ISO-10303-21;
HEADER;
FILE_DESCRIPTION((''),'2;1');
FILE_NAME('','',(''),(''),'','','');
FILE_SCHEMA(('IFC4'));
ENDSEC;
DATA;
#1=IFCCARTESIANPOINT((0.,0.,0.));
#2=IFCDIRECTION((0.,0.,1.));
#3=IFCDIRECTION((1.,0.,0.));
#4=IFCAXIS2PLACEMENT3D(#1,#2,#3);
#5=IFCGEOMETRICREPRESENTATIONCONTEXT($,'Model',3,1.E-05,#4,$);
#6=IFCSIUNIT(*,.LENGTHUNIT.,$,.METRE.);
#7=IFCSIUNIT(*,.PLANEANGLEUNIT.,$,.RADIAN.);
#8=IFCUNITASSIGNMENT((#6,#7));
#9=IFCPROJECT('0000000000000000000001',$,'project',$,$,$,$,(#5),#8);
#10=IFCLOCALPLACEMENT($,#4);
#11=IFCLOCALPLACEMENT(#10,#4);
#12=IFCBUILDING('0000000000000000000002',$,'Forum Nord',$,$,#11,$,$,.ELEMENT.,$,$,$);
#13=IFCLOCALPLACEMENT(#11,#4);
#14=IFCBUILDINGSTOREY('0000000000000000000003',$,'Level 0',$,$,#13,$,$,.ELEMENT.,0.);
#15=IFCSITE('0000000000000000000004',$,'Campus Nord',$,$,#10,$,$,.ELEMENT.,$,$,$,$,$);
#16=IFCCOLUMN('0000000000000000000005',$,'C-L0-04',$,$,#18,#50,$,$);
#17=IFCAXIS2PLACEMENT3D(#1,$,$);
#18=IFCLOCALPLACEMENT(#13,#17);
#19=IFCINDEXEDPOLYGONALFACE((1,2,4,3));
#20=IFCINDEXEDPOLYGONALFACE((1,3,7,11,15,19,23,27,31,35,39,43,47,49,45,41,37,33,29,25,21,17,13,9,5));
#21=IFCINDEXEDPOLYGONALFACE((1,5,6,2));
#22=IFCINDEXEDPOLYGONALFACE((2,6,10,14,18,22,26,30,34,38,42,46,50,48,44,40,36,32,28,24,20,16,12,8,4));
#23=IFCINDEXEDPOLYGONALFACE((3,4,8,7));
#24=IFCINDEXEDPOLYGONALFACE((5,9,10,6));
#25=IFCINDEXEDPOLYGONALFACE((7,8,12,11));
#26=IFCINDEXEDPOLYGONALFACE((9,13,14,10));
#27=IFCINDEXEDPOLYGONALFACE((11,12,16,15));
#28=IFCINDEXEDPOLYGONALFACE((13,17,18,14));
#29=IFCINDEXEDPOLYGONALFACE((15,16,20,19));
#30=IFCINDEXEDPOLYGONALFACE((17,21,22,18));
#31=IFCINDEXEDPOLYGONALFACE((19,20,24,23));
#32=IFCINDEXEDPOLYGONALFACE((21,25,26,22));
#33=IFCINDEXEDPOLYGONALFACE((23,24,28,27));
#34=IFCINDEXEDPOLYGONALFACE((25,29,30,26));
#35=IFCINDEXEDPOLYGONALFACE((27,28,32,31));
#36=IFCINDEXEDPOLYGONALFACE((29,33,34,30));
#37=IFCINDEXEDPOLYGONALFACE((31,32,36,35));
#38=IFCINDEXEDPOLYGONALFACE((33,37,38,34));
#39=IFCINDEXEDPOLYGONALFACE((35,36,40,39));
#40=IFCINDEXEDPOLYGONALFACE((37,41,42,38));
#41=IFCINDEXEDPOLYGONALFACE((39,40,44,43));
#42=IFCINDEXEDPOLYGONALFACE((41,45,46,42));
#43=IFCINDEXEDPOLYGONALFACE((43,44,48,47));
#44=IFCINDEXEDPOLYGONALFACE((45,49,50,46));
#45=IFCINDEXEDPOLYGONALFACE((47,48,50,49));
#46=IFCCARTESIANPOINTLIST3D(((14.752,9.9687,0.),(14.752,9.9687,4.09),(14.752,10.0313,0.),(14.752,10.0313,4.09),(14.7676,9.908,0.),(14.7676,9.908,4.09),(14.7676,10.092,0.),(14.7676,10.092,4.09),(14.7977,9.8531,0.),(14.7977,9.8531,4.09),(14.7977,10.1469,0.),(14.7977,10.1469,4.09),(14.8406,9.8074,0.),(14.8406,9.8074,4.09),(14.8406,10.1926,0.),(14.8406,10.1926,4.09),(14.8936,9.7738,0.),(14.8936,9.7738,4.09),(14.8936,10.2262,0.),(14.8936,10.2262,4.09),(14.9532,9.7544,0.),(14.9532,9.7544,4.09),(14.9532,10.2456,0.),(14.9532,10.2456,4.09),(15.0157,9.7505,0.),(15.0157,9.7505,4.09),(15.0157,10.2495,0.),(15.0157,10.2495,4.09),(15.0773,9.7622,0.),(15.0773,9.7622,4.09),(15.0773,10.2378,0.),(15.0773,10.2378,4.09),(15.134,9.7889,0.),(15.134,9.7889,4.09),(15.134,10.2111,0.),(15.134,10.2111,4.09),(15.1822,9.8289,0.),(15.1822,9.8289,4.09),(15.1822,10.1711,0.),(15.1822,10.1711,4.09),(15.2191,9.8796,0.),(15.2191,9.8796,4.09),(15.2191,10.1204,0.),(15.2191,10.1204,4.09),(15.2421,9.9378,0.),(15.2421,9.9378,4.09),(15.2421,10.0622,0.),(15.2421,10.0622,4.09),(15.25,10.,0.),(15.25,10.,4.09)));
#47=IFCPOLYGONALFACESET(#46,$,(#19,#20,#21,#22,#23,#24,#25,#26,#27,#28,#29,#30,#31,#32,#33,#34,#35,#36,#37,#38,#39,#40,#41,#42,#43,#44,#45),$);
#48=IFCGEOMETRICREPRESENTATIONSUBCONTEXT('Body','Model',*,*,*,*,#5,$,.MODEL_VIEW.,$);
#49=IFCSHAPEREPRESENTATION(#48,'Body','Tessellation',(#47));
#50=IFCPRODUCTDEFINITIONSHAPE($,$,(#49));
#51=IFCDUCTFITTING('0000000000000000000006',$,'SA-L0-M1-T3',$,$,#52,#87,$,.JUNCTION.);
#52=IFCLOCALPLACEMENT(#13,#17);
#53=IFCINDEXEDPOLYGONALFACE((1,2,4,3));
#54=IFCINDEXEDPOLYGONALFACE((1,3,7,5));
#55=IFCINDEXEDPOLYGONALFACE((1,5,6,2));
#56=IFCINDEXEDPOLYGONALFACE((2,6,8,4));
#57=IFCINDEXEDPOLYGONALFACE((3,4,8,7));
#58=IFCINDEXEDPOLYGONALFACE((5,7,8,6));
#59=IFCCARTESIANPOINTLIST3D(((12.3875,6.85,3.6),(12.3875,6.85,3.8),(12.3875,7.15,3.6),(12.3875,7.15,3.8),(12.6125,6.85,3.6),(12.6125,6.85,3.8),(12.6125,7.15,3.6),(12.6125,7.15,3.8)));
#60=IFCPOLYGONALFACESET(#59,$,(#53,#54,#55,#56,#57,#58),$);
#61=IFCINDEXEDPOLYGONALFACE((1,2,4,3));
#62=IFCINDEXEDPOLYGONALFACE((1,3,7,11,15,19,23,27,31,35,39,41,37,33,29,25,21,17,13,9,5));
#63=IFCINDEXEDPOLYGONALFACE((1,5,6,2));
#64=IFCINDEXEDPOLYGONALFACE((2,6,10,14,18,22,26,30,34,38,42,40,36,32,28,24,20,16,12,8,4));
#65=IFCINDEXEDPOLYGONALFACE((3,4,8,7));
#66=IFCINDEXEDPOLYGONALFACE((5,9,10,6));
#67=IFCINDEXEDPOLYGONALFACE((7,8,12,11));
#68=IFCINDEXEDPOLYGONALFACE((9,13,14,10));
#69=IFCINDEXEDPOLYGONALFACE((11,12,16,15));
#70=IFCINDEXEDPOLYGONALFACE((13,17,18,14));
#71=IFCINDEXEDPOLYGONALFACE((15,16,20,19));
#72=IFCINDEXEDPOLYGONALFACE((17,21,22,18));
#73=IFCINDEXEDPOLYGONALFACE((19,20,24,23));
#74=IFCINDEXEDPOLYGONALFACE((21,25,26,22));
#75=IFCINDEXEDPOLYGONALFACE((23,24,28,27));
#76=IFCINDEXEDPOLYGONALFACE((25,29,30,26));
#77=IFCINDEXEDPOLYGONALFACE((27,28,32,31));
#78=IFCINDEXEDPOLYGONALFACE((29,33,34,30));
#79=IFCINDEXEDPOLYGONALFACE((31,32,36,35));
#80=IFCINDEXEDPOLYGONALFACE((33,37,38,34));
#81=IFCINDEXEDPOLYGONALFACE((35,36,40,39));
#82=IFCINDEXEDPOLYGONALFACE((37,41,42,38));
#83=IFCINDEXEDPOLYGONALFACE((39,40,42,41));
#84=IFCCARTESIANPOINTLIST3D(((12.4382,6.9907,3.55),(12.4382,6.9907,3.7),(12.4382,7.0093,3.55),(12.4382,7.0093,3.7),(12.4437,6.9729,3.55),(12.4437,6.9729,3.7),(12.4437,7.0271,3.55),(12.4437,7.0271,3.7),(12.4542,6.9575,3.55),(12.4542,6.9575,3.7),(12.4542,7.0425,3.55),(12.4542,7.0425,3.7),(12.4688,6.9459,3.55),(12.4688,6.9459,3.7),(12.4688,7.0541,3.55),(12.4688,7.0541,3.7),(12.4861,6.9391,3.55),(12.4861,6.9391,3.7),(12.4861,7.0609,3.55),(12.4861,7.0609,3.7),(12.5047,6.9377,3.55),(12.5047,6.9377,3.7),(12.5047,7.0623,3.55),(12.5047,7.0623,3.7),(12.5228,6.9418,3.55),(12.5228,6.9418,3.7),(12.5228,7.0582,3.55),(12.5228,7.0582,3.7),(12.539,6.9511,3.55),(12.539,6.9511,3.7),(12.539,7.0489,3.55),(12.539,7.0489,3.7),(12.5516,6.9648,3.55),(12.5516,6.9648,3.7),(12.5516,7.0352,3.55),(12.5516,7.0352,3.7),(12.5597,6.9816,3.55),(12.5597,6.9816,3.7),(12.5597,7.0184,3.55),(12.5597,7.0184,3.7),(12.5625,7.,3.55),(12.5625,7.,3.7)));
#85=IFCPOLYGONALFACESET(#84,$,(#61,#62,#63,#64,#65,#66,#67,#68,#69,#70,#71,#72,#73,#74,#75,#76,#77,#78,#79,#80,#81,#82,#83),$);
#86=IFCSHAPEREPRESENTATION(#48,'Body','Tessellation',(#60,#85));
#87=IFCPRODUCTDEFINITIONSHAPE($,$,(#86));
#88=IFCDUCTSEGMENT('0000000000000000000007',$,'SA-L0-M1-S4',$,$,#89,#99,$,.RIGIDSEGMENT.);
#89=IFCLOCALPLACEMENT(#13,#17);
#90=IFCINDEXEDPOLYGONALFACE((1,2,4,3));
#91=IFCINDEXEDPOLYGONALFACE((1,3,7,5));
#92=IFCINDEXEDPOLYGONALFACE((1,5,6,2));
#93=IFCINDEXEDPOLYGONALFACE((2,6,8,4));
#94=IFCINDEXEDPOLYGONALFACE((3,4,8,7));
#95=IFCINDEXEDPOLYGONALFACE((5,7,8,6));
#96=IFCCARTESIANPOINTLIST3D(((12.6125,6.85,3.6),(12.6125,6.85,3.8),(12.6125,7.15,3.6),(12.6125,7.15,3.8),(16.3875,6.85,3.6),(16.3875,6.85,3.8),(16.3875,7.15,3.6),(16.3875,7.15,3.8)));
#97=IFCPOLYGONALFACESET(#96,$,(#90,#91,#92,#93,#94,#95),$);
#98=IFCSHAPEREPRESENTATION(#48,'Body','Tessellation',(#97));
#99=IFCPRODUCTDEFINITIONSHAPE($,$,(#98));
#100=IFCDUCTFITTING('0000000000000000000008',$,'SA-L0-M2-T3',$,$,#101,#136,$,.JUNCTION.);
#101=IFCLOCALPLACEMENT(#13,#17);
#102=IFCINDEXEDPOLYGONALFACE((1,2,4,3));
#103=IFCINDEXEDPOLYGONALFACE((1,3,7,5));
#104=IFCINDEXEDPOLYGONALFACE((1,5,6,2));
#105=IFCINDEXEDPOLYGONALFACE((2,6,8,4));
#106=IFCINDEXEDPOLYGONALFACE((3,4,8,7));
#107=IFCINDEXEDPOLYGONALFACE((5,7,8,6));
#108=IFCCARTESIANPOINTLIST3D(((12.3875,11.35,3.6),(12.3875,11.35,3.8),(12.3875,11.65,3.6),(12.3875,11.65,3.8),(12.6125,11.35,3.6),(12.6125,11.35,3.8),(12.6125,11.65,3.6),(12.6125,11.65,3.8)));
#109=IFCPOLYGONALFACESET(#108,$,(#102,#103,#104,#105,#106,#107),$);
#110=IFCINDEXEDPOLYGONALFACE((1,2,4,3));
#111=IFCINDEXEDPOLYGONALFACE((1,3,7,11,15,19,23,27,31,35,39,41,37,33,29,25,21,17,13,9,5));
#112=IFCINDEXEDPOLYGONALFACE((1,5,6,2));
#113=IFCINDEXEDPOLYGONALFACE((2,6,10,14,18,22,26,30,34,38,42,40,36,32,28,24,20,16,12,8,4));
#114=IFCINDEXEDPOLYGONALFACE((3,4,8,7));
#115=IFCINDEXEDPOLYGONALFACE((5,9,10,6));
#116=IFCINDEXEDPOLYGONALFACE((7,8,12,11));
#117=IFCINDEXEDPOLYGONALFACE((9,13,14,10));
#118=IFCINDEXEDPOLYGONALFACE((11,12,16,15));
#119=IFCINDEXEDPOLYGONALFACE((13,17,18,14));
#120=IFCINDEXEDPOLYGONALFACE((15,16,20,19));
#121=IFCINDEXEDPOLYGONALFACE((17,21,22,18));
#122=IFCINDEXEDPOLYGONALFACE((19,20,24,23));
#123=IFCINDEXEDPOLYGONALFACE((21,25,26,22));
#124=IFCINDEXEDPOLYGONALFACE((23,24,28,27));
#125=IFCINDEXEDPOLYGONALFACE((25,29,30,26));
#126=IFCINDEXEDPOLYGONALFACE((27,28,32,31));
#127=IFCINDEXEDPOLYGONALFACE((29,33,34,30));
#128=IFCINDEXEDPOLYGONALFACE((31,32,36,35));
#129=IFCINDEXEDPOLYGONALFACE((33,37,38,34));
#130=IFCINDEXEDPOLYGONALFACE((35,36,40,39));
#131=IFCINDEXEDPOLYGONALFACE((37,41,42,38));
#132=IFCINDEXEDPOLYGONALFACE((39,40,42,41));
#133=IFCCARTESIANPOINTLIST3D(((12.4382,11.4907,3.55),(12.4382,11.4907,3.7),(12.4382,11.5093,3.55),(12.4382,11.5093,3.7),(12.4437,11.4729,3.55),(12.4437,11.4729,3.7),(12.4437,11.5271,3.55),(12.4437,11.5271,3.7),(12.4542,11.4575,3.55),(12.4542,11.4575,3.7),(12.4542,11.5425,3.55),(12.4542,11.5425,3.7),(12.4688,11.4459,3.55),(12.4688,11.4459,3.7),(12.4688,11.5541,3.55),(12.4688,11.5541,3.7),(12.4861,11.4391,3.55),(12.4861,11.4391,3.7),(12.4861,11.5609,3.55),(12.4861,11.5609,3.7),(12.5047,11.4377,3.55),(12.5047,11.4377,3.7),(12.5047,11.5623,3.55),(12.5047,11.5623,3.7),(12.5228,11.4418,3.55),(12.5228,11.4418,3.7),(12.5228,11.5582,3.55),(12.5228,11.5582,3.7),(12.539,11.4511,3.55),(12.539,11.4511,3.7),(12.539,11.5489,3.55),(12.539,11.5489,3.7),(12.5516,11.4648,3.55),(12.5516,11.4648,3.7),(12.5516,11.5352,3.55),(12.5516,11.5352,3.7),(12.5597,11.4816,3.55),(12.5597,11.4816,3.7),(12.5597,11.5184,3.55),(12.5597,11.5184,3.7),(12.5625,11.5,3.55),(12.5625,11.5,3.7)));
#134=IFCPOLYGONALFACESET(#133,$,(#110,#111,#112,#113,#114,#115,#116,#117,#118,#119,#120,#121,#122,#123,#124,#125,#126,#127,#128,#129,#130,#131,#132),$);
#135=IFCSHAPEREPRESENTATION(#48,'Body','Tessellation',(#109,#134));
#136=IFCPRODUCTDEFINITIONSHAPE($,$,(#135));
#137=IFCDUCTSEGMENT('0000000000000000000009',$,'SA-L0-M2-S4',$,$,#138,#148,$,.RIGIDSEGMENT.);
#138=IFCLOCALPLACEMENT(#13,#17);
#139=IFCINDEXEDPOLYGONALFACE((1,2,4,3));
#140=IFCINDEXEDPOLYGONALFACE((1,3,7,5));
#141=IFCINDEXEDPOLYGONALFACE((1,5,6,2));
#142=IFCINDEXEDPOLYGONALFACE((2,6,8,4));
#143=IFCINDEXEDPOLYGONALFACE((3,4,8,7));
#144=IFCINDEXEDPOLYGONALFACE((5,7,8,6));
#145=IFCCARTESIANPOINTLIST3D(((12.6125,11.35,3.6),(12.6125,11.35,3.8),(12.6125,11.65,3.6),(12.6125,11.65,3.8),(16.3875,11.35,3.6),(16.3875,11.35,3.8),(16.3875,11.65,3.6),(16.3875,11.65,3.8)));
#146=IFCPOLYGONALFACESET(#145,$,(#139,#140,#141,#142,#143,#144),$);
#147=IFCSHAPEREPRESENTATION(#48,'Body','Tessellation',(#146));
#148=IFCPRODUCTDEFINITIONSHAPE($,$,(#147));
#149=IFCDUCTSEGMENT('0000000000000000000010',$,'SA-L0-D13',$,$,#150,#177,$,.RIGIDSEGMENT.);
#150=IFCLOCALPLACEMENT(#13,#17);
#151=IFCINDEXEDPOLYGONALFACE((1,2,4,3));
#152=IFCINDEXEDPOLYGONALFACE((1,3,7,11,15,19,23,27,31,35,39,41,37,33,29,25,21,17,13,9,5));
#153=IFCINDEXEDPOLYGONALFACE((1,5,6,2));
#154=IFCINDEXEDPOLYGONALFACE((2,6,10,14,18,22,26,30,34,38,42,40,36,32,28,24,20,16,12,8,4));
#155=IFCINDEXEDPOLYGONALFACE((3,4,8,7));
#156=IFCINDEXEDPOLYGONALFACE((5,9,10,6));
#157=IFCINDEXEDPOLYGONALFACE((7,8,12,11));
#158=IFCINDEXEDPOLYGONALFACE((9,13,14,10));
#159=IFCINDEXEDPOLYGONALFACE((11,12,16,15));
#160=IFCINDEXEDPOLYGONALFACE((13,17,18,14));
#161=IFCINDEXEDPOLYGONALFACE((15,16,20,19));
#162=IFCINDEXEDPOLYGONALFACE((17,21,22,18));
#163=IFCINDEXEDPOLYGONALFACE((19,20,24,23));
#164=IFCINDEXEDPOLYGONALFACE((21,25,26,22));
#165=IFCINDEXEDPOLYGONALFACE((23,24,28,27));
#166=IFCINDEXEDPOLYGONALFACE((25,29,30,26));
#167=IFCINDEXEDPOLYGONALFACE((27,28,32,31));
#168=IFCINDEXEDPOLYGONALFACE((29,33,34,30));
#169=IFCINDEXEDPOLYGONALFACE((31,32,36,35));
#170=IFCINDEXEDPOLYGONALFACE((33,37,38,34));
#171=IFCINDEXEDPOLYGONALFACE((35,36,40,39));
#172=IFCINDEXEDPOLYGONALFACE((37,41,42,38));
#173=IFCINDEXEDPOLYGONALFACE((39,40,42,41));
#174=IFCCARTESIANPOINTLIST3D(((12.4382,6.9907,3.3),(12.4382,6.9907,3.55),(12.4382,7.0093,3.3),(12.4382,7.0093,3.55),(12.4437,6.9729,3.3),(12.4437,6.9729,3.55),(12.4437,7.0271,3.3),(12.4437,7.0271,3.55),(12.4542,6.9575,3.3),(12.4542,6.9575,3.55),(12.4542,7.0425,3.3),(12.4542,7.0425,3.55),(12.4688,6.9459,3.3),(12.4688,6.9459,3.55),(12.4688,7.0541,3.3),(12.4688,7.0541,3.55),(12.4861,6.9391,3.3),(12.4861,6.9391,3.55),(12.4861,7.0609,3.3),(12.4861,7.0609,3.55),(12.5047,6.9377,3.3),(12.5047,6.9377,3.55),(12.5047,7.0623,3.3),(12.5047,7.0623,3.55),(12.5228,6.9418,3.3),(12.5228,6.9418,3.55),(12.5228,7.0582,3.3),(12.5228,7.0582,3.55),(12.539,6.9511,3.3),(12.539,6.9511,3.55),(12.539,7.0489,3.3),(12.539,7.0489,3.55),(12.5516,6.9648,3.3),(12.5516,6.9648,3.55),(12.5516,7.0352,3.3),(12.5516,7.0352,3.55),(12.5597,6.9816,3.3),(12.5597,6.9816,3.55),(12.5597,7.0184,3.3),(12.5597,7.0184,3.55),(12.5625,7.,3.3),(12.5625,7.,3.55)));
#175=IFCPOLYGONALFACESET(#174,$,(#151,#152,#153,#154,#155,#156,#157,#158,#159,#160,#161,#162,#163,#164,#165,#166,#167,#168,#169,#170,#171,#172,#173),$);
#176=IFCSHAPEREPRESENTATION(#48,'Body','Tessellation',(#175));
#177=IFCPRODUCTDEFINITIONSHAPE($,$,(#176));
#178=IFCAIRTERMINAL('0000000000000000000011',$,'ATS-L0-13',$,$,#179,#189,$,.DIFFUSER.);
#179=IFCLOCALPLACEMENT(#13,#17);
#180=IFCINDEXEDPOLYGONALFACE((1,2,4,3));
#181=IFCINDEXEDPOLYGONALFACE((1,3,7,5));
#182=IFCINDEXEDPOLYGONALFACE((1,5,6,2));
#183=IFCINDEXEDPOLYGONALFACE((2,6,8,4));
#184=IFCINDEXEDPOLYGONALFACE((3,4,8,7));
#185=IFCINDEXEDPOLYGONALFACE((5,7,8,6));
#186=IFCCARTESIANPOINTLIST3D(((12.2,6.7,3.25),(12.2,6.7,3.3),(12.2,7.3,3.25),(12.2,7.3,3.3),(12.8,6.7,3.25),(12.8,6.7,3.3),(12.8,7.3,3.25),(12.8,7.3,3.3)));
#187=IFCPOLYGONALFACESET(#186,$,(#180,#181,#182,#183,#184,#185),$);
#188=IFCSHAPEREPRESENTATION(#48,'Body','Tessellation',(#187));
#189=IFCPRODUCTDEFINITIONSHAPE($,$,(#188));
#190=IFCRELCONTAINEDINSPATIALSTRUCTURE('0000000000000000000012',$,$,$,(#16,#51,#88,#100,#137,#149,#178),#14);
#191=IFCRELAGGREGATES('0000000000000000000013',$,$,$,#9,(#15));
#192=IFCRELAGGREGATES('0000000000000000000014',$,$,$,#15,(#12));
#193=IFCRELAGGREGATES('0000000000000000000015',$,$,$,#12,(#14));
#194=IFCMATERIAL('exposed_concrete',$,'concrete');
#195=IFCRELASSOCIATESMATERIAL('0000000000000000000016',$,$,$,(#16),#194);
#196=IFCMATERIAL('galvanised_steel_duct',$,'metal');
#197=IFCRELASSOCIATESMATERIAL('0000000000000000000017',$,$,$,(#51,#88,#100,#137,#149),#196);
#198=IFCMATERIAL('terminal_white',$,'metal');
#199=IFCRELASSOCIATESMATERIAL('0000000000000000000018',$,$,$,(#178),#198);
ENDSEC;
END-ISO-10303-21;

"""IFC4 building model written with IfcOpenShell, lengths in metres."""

from ifc_helpers import new_model, si_unit, frame, origin_with_axes, origin_2d_with_axis, place, context, subcontext, project, spatial, rectangle, circle, extrude, material, element, save


model = new_model("IFC4")

# Units and contexts
model_context = context("Model", 3, precision=1e-05, world=origin_with_axes())
body_context = subcontext(model_context, "Body", "Model", "MODEL_VIEW")
ifc_project = project(units=[si_unit("LENGTHUNIT", "METRE"), si_unit("PLANEANGLEUNIT", "RADIAN")], contexts=[model_context])

# Site, building, storey
site_placement = place(None, origin_with_axes())
site = spatial("IfcSite", under=ifc_project, at=site_placement, Name="Campus Nord", CompositionType="ELEMENT")
building_placement = place(site_placement, origin_with_axes())
building = spatial("IfcBuilding", under=site, at=building_placement, Name="Forum Nord", CompositionType="ELEMENT")
storey_placement = place(building_placement, origin_with_axes())
storey = spatial("IfcBuildingStorey", under=building, at=storey_placement, Name="Level 0", CompositionType="ELEMENT", Elevation=0.0)

# Column
ifc_material_1 = material(Name="exposed_concrete", Category="concrete")
column_placement = place(storey_placement, frame((15.0, 10.0, 0.0), z_axis=(0.0, 0.0, 1.0), x_axis=(1.0, 0.0, 0.0)))
element("IfcColumn", 1, at=column_placement, inside=storey, material=ifc_material_1, Name="C-L0-04", context=body_context, shape_type="SweptSolid", body=[
    extrude(circle(Radius=0.25, at=origin_2d_with_axis()), origin_with_axes(), (0.0, 0.0, 1.0), 4.09),
])

# Duct fitting
ifc_material_2 = material(Name="galvanised_steel_duct", Category="metal")
duct_fitting_1_placement = place(storey_placement, frame((12.3875, 7.0, 3.7), z_axis=(1.0, 0.0, 0.0), x_axis=(0.0, 1.0, 0.0)))
element("IfcDuctFitting", 2, at=duct_fitting_1_placement, inside=storey, material=ifc_material_2, Name="SA-L0-M1-T3", PredefinedType="JUNCTION", context=body_context, shape_type="SweptSolid", body=[
    extrude(rectangle(XDim=0.3, YDim=0.2, at=origin_2d_with_axis()), origin_with_axes(), (0.0, 0.0, 1.0), 0.225),
    extrude(circle(Radius=0.0625, at=origin_2d_with_axis()), frame((0.0, 0.0, 0.1125), z_axis=(0.0, -1.0, 0.0), x_axis=(0.0, 0.0, 1.0)), (0.0, 0.0, 1.0), 0.15),
])

# Duct segment
duct_segment_1_placement = place(storey_placement, frame((12.6125, 7.0, 3.7), z_axis=(1.0, 0.0, 0.0), x_axis=(0.0, 1.0, 0.0)))
element("IfcDuctSegment", 3, at=duct_segment_1_placement, inside=storey, material=ifc_material_2, Name="SA-L0-M1-S4", PredefinedType="RIGIDSEGMENT", context=body_context, shape_type="SweptSolid", body=[
    extrude(rectangle(XDim=0.3, YDim=0.2, at=origin_2d_with_axis()), origin_with_axes(), (0.0, 0.0, 1.0), 3.775),
])

# Duct fitting
duct_fitting_2_placement = place(storey_placement, frame((12.3875, 11.5, 3.7), z_axis=(1.0, 0.0, 0.0), x_axis=(0.0, 1.0, 0.0)))
element("IfcDuctFitting", 4, at=duct_fitting_2_placement, inside=storey, material=ifc_material_2, Name="SA-L0-M2-T3", PredefinedType="JUNCTION", context=body_context, shape_type="SweptSolid", body=[
    extrude(rectangle(XDim=0.3, YDim=0.2, at=origin_2d_with_axis()), origin_with_axes(), (0.0, 0.0, 1.0), 0.225),
    extrude(circle(Radius=0.0625, at=origin_2d_with_axis()), frame((0.0, 0.0, 0.1125), z_axis=(0.0, -1.0, 0.0), x_axis=(0.0, 0.0, 1.0)), (0.0, 0.0, 1.0), 0.15),
])

# Duct segments
duct_segment_2_placement = place(storey_placement, frame((12.6125, 11.5, 3.7), z_axis=(1.0, 0.0, 0.0), x_axis=(0.0, 1.0, 0.0)))
element("IfcDuctSegment", 5, at=duct_segment_2_placement, inside=storey, material=ifc_material_2, Name="SA-L0-M2-S4", PredefinedType="RIGIDSEGMENT", context=body_context, shape_type="SweptSolid", body=[
    extrude(rectangle(XDim=0.3, YDim=0.2, at=origin_2d_with_axis()), origin_with_axes(), (0.0, 0.0, 1.0), 3.775),
])
duct_segment_3_placement = place(storey_placement, frame((12.5, 7.0, 3.55), z_axis=(0.0, 0.0, -1.0), x_axis=(1.0, 0.0, 0.0)))
element("IfcDuctSegment", 6, at=duct_segment_3_placement, inside=storey, material=ifc_material_2, Name="SA-L0-D13", PredefinedType="RIGIDSEGMENT", context=body_context, shape_type="SweptSolid", body=[
    extrude(circle(Radius=0.0625, at=origin_2d_with_axis()), origin_with_axes(), (0.0, 0.0, 1.0), 0.25),
])

# Air terminal
ifc_material_3 = material(Name="terminal_white", Category="metal")
air_terminal_1_placement = place(storey_placement, frame((12.5, 7.0, 3.25), z_axis=(0.0, 0.0, 1.0), x_axis=(1.0, 0.0, 0.0)))
element("IfcAirTerminal", 7, at=air_terminal_1_placement, inside=storey, material=ifc_material_3, Name="ATS-L0-13", PredefinedType="DIFFUSER", context=body_context, shape_type="SweptSolid", body=[
    extrude(rectangle(XDim=0.6, YDim=0.6, at=origin_2d_with_axis()), origin_with_axes(), (0.0, 0.0, 1.0), 0.05),
])

save(model, "model.ifc")
